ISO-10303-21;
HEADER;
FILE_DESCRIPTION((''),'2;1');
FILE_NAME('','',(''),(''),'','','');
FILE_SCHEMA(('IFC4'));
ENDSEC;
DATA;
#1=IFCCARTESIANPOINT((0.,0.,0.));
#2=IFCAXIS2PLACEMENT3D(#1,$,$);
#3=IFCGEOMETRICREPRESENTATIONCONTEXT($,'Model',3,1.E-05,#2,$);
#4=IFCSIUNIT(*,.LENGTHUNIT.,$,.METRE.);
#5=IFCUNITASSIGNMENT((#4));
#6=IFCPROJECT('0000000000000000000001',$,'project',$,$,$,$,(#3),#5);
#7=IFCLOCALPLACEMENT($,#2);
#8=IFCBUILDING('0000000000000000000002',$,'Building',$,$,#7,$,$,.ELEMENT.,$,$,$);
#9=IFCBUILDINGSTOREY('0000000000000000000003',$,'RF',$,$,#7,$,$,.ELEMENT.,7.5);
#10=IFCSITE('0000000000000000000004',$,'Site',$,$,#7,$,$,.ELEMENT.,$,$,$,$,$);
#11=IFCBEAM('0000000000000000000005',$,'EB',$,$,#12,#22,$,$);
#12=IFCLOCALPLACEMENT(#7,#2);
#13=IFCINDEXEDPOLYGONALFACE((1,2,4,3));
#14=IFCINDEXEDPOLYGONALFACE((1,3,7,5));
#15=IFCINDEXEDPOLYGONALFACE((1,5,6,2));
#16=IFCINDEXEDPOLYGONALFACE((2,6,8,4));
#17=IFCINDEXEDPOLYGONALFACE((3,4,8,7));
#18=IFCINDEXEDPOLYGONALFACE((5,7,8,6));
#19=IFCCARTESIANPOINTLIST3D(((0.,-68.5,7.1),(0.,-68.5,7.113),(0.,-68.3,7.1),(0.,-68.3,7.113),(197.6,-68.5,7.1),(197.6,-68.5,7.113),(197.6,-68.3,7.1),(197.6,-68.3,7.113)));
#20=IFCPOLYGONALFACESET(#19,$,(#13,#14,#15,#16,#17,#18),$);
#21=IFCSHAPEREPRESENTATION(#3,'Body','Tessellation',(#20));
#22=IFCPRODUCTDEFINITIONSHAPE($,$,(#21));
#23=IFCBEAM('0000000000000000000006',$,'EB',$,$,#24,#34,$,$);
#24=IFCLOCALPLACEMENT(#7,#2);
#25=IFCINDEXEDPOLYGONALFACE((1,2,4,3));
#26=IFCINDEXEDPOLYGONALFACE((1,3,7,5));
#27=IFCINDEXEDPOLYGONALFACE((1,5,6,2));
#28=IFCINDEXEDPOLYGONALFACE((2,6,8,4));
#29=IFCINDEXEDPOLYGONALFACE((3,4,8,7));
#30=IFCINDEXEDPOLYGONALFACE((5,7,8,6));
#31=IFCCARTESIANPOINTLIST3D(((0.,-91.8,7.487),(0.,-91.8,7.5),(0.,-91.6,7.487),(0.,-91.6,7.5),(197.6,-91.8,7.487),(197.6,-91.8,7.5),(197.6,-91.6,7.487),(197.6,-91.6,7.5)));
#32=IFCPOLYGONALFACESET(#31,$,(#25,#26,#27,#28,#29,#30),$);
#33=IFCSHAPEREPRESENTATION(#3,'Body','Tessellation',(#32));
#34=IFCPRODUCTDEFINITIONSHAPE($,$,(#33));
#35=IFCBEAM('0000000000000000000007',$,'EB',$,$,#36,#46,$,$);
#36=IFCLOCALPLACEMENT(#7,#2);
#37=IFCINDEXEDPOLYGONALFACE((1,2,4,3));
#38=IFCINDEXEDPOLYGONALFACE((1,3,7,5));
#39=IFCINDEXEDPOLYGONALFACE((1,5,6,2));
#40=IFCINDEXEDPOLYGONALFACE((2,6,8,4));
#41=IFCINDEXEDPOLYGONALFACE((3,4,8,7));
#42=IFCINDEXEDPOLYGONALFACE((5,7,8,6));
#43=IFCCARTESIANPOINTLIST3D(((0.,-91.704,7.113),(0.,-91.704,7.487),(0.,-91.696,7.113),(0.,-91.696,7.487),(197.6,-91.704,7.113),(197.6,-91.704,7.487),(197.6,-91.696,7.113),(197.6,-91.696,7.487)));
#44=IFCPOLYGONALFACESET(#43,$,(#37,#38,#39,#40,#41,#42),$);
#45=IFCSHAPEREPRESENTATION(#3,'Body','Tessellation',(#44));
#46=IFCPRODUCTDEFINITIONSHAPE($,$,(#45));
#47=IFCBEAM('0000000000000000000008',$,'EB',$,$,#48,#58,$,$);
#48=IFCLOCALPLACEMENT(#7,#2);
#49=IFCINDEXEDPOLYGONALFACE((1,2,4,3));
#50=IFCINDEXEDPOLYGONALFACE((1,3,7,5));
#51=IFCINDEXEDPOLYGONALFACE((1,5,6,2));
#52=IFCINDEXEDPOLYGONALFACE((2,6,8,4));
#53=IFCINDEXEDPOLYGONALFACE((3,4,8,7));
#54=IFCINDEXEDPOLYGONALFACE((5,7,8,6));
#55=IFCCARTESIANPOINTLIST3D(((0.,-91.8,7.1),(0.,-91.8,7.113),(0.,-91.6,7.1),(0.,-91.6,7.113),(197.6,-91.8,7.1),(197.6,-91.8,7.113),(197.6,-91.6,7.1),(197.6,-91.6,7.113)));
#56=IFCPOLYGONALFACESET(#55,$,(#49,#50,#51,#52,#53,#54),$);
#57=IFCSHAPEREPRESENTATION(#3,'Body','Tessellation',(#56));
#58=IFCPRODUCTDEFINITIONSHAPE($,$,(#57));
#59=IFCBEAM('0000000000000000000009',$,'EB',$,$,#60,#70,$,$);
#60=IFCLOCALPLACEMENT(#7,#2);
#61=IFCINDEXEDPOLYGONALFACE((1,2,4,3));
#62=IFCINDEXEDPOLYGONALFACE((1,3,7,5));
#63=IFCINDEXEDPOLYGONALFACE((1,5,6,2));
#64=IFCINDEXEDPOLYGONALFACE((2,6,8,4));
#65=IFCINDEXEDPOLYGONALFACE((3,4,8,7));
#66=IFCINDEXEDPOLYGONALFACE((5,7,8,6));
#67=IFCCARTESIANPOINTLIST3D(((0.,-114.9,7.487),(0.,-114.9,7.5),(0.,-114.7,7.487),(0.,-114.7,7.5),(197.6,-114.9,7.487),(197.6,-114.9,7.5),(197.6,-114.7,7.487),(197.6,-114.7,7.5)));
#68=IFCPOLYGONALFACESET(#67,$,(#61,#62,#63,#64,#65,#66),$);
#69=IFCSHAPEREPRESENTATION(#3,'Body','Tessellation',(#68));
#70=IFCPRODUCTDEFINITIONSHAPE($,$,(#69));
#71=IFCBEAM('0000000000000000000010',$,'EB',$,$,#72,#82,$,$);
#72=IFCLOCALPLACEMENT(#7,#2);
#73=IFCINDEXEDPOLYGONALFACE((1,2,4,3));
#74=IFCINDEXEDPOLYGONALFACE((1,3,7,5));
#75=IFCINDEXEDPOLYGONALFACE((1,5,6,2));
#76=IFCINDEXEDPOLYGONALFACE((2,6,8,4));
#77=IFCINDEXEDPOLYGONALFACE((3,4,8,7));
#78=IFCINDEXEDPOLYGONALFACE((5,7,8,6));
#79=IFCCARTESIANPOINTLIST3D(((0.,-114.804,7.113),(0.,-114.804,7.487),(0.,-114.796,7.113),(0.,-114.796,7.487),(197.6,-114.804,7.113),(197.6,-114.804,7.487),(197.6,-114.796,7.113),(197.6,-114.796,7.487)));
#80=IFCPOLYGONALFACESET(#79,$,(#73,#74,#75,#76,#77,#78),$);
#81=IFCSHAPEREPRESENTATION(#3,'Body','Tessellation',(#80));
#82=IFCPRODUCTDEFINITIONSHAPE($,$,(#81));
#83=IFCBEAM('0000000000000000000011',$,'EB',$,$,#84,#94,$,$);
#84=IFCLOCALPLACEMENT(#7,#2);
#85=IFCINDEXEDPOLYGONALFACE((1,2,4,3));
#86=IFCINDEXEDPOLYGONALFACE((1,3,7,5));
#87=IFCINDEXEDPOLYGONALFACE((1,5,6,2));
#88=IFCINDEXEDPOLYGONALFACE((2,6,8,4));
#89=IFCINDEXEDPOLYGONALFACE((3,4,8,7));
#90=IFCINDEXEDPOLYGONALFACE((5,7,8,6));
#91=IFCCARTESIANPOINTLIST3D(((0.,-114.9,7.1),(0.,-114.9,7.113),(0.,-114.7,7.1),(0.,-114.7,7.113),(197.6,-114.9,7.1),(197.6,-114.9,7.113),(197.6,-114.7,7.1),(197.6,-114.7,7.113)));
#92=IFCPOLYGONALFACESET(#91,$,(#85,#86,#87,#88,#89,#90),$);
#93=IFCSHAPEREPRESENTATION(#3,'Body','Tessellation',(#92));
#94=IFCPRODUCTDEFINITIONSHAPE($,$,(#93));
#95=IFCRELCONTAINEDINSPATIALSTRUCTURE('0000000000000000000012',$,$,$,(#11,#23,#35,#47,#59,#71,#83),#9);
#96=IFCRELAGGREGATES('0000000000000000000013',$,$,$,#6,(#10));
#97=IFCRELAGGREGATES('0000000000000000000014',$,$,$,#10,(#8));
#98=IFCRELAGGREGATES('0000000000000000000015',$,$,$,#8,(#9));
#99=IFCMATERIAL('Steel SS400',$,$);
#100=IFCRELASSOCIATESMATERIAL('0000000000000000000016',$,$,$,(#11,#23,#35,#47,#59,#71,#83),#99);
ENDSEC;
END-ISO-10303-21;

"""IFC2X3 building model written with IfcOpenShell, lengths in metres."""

from ifc_helpers import new_model, si_unit, frame, origin, origin_2d, place, context, project, spatial, rectangle, extrude, material, element, save


model = new_model("IFC2X3")

# Units and contexts
model_context = context("Model", 3, precision=1e-05, world=origin())
ifc_project = project(units=[si_unit("LENGTHUNIT", "METRE")], contexts=[model_context])

# Site, building, storey
placement = place(None, origin())
site = spatial("IfcSite", under=ifc_project, at=placement, Name="Site", CompositionType="ELEMENT")
building = spatial("IfcBuilding", under=site, at=placement, Name="Building", CompositionType="ELEMENT")
storey = spatial("IfcBuildingStorey", under=building, at=placement, Name="RF", CompositionType="ELEMENT", Elevation=7.5)

# Beams
ifc_material = material(Name="Steel SS400")
for number, where, name in (
    (1, (98.8, -68.4, 7.1), "EB"),
    (2, (98.8, -91.7, 7.487), "EB"),
):
    element("IfcBeam", number, at=place(None, frame(where)), inside=storey, material=ifc_material, Name=name, context=model_context, shape_type="SweptSolid", body=[
        extrude(rectangle(XDim=197.6, YDim=0.2, at=origin_2d()), origin(), (0.0, 0.0, 1.0), 0.013),
    ])
beam_1_placement = place(None, frame((98.8, -91.7, 7.113)))
element("IfcBeam", 3, at=beam_1_placement, inside=storey, material=ifc_material, Name="EB", context=model_context, shape_type="SweptSolid", body=[
    extrude(rectangle(XDim=197.6, YDim=0.008, at=origin_2d()), origin(), (0.0, 0.0, 1.0), 0.374),
])
for number, where, name in (
    (4, (98.8, -91.7, 7.1), "EB"),
    (5, (98.8, -114.8, 7.487), "EB"),
):
    element("IfcBeam", number, at=place(None, frame(where)), inside=storey, material=ifc_material, Name=name, context=model_context, shape_type="SweptSolid", body=[
        extrude(rectangle(XDim=197.6, YDim=0.2, at=origin_2d()), origin(), (0.0, 0.0, 1.0), 0.013),
    ])
beam_2_placement = place(None, frame((98.8, -114.8, 7.113)))
element("IfcBeam", 6, at=beam_2_placement, inside=storey, material=ifc_material, Name="EB", context=model_context, shape_type="SweptSolid", body=[
    extrude(rectangle(XDim=197.6, YDim=0.008, at=origin_2d()), origin(), (0.0, 0.0, 1.0), 0.374),
])
beam_3_placement = place(None, frame((98.8, -114.8, 7.1)))
element("IfcBeam", 7, at=beam_3_placement, inside=storey, material=ifc_material, Name="EB", context=model_context, shape_type="SweptSolid", body=[
    extrude(rectangle(XDim=197.6, YDim=0.2, at=origin_2d()), origin(), (0.0, 0.0, 1.0), 0.013),
])

save(model, "model.ifc")
